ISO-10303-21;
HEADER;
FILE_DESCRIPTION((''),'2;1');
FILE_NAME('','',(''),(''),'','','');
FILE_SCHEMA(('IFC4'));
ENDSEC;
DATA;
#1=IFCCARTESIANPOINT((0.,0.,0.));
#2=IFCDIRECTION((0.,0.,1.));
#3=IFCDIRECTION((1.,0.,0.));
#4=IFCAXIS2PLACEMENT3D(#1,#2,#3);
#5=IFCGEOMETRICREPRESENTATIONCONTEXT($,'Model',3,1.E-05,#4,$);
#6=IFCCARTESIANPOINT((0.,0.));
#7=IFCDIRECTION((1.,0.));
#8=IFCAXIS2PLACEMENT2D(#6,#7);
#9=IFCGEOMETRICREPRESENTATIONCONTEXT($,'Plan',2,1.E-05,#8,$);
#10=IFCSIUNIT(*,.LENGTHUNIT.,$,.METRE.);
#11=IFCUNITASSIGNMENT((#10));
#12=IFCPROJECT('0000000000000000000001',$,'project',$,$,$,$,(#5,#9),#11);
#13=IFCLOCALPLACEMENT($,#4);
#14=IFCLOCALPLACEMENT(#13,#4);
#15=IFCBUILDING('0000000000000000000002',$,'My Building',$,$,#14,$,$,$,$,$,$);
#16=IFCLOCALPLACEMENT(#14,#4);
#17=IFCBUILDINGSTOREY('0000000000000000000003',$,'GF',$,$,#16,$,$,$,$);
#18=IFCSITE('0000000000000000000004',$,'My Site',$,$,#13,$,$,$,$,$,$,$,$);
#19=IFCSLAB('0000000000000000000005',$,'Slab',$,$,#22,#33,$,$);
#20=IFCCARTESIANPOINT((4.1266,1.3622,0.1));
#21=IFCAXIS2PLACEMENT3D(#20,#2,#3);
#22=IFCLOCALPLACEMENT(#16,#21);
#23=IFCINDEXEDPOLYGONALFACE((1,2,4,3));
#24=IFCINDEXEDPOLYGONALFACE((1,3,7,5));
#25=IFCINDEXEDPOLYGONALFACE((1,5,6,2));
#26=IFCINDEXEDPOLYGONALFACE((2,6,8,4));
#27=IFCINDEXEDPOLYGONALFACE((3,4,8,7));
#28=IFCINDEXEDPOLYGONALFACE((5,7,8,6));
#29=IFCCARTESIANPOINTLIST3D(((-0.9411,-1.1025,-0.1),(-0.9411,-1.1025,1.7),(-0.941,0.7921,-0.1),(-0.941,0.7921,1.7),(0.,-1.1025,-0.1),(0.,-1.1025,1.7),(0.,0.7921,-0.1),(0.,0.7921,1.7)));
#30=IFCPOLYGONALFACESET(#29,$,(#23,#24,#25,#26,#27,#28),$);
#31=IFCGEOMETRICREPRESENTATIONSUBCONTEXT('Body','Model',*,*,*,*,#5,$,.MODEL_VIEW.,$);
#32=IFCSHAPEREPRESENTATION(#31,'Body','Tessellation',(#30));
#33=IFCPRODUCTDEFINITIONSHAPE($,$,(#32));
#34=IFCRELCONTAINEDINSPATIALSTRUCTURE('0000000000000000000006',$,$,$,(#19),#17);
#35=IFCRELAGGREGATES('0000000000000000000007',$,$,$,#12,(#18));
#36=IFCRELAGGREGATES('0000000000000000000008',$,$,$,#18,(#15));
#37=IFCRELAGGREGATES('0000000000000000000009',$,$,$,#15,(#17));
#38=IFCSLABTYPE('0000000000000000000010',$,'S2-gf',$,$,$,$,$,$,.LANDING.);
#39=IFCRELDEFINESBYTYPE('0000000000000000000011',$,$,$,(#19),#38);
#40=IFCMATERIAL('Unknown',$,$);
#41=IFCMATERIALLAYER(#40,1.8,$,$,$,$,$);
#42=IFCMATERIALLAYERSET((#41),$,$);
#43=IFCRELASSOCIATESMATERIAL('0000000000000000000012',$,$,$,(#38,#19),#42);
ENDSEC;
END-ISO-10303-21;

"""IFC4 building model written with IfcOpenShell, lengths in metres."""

from ifc_helpers import new_model, si_unit, frame, origin_with_axes, origin_2d_with_axis, place, context, subcontext, project, spatial, indexed_curve, outline, extrude, material, layer, layer_set, layer_usage, type_object, element, save


model = new_model("IFC4")

# Units and contexts
model_context = context("Model", 3, precision=1e-05, world=origin_with_axes())
plan_context = context("Plan", 2, precision=1e-05, world=origin_2d_with_axis())
body_context_1 = subcontext(model_context, "Body", "Model", "MODEL_VIEW")
ifc_project = project(units=[si_unit("LENGTHUNIT", "METRE")], contexts=[model_context, plan_context])

# Site, building, storey
site_placement = place(None, origin_with_axes())
site = spatial("IfcSite", under=ifc_project, at=site_placement, Name="My Site")
building_placement = place(site_placement, origin_with_axes())
building = spatial("IfcBuilding", under=site, at=building_placement, Name="My Building")
storey_placement = place(building_placement, origin_with_axes())
storey = spatial("IfcBuildingStorey", under=building, at=storey_placement, Name="GF")

# Shared definitions
ifc_material = material(Name="Unknown")

# Slab
ifc_layer_1 = layer(ifc_material, 1.8)
ifc_layer_set_1 = layer_set([ifc_layer_1])
ifc_layer_usage_1 = layer_usage(ifc_layer_set_1, "AXIS3", "POSITIVE", -0.1)
slab_type_1 = type_object("IfcSlabType", Name="S2-gf", PredefinedType="LANDING", material=ifc_layer_set_1)
slab_1_placement = place(storey_placement, frame((4.1266, 1.3622, 0.1), z_axis=(0.0, 0.0, 1.0), x_axis=(1.0, 0.0, 0.0)))
element("IfcSlab", 1, at=slab_1_placement, inside=storey, type_object=slab_type_1, material=ifc_layer_usage_1, Name="Slab", context=body_context_1, shape_type="SweptSolid", body=[
    extrude(outline(indexed_curve([(0.0, 0.7921), (0.0, -1.1025), (-0.9411, -1.1025), (-0.941, 0.7921), (0.0, 0.7921)])), frame((0.0, 0.0, -0.1), z_axis=(0.0, 0.0, 1.0), x_axis=(1.0, 0.0, 0.0)), (0.0, 0.0, 1.0), 1.8),
])

save(model, "model.ifc")
